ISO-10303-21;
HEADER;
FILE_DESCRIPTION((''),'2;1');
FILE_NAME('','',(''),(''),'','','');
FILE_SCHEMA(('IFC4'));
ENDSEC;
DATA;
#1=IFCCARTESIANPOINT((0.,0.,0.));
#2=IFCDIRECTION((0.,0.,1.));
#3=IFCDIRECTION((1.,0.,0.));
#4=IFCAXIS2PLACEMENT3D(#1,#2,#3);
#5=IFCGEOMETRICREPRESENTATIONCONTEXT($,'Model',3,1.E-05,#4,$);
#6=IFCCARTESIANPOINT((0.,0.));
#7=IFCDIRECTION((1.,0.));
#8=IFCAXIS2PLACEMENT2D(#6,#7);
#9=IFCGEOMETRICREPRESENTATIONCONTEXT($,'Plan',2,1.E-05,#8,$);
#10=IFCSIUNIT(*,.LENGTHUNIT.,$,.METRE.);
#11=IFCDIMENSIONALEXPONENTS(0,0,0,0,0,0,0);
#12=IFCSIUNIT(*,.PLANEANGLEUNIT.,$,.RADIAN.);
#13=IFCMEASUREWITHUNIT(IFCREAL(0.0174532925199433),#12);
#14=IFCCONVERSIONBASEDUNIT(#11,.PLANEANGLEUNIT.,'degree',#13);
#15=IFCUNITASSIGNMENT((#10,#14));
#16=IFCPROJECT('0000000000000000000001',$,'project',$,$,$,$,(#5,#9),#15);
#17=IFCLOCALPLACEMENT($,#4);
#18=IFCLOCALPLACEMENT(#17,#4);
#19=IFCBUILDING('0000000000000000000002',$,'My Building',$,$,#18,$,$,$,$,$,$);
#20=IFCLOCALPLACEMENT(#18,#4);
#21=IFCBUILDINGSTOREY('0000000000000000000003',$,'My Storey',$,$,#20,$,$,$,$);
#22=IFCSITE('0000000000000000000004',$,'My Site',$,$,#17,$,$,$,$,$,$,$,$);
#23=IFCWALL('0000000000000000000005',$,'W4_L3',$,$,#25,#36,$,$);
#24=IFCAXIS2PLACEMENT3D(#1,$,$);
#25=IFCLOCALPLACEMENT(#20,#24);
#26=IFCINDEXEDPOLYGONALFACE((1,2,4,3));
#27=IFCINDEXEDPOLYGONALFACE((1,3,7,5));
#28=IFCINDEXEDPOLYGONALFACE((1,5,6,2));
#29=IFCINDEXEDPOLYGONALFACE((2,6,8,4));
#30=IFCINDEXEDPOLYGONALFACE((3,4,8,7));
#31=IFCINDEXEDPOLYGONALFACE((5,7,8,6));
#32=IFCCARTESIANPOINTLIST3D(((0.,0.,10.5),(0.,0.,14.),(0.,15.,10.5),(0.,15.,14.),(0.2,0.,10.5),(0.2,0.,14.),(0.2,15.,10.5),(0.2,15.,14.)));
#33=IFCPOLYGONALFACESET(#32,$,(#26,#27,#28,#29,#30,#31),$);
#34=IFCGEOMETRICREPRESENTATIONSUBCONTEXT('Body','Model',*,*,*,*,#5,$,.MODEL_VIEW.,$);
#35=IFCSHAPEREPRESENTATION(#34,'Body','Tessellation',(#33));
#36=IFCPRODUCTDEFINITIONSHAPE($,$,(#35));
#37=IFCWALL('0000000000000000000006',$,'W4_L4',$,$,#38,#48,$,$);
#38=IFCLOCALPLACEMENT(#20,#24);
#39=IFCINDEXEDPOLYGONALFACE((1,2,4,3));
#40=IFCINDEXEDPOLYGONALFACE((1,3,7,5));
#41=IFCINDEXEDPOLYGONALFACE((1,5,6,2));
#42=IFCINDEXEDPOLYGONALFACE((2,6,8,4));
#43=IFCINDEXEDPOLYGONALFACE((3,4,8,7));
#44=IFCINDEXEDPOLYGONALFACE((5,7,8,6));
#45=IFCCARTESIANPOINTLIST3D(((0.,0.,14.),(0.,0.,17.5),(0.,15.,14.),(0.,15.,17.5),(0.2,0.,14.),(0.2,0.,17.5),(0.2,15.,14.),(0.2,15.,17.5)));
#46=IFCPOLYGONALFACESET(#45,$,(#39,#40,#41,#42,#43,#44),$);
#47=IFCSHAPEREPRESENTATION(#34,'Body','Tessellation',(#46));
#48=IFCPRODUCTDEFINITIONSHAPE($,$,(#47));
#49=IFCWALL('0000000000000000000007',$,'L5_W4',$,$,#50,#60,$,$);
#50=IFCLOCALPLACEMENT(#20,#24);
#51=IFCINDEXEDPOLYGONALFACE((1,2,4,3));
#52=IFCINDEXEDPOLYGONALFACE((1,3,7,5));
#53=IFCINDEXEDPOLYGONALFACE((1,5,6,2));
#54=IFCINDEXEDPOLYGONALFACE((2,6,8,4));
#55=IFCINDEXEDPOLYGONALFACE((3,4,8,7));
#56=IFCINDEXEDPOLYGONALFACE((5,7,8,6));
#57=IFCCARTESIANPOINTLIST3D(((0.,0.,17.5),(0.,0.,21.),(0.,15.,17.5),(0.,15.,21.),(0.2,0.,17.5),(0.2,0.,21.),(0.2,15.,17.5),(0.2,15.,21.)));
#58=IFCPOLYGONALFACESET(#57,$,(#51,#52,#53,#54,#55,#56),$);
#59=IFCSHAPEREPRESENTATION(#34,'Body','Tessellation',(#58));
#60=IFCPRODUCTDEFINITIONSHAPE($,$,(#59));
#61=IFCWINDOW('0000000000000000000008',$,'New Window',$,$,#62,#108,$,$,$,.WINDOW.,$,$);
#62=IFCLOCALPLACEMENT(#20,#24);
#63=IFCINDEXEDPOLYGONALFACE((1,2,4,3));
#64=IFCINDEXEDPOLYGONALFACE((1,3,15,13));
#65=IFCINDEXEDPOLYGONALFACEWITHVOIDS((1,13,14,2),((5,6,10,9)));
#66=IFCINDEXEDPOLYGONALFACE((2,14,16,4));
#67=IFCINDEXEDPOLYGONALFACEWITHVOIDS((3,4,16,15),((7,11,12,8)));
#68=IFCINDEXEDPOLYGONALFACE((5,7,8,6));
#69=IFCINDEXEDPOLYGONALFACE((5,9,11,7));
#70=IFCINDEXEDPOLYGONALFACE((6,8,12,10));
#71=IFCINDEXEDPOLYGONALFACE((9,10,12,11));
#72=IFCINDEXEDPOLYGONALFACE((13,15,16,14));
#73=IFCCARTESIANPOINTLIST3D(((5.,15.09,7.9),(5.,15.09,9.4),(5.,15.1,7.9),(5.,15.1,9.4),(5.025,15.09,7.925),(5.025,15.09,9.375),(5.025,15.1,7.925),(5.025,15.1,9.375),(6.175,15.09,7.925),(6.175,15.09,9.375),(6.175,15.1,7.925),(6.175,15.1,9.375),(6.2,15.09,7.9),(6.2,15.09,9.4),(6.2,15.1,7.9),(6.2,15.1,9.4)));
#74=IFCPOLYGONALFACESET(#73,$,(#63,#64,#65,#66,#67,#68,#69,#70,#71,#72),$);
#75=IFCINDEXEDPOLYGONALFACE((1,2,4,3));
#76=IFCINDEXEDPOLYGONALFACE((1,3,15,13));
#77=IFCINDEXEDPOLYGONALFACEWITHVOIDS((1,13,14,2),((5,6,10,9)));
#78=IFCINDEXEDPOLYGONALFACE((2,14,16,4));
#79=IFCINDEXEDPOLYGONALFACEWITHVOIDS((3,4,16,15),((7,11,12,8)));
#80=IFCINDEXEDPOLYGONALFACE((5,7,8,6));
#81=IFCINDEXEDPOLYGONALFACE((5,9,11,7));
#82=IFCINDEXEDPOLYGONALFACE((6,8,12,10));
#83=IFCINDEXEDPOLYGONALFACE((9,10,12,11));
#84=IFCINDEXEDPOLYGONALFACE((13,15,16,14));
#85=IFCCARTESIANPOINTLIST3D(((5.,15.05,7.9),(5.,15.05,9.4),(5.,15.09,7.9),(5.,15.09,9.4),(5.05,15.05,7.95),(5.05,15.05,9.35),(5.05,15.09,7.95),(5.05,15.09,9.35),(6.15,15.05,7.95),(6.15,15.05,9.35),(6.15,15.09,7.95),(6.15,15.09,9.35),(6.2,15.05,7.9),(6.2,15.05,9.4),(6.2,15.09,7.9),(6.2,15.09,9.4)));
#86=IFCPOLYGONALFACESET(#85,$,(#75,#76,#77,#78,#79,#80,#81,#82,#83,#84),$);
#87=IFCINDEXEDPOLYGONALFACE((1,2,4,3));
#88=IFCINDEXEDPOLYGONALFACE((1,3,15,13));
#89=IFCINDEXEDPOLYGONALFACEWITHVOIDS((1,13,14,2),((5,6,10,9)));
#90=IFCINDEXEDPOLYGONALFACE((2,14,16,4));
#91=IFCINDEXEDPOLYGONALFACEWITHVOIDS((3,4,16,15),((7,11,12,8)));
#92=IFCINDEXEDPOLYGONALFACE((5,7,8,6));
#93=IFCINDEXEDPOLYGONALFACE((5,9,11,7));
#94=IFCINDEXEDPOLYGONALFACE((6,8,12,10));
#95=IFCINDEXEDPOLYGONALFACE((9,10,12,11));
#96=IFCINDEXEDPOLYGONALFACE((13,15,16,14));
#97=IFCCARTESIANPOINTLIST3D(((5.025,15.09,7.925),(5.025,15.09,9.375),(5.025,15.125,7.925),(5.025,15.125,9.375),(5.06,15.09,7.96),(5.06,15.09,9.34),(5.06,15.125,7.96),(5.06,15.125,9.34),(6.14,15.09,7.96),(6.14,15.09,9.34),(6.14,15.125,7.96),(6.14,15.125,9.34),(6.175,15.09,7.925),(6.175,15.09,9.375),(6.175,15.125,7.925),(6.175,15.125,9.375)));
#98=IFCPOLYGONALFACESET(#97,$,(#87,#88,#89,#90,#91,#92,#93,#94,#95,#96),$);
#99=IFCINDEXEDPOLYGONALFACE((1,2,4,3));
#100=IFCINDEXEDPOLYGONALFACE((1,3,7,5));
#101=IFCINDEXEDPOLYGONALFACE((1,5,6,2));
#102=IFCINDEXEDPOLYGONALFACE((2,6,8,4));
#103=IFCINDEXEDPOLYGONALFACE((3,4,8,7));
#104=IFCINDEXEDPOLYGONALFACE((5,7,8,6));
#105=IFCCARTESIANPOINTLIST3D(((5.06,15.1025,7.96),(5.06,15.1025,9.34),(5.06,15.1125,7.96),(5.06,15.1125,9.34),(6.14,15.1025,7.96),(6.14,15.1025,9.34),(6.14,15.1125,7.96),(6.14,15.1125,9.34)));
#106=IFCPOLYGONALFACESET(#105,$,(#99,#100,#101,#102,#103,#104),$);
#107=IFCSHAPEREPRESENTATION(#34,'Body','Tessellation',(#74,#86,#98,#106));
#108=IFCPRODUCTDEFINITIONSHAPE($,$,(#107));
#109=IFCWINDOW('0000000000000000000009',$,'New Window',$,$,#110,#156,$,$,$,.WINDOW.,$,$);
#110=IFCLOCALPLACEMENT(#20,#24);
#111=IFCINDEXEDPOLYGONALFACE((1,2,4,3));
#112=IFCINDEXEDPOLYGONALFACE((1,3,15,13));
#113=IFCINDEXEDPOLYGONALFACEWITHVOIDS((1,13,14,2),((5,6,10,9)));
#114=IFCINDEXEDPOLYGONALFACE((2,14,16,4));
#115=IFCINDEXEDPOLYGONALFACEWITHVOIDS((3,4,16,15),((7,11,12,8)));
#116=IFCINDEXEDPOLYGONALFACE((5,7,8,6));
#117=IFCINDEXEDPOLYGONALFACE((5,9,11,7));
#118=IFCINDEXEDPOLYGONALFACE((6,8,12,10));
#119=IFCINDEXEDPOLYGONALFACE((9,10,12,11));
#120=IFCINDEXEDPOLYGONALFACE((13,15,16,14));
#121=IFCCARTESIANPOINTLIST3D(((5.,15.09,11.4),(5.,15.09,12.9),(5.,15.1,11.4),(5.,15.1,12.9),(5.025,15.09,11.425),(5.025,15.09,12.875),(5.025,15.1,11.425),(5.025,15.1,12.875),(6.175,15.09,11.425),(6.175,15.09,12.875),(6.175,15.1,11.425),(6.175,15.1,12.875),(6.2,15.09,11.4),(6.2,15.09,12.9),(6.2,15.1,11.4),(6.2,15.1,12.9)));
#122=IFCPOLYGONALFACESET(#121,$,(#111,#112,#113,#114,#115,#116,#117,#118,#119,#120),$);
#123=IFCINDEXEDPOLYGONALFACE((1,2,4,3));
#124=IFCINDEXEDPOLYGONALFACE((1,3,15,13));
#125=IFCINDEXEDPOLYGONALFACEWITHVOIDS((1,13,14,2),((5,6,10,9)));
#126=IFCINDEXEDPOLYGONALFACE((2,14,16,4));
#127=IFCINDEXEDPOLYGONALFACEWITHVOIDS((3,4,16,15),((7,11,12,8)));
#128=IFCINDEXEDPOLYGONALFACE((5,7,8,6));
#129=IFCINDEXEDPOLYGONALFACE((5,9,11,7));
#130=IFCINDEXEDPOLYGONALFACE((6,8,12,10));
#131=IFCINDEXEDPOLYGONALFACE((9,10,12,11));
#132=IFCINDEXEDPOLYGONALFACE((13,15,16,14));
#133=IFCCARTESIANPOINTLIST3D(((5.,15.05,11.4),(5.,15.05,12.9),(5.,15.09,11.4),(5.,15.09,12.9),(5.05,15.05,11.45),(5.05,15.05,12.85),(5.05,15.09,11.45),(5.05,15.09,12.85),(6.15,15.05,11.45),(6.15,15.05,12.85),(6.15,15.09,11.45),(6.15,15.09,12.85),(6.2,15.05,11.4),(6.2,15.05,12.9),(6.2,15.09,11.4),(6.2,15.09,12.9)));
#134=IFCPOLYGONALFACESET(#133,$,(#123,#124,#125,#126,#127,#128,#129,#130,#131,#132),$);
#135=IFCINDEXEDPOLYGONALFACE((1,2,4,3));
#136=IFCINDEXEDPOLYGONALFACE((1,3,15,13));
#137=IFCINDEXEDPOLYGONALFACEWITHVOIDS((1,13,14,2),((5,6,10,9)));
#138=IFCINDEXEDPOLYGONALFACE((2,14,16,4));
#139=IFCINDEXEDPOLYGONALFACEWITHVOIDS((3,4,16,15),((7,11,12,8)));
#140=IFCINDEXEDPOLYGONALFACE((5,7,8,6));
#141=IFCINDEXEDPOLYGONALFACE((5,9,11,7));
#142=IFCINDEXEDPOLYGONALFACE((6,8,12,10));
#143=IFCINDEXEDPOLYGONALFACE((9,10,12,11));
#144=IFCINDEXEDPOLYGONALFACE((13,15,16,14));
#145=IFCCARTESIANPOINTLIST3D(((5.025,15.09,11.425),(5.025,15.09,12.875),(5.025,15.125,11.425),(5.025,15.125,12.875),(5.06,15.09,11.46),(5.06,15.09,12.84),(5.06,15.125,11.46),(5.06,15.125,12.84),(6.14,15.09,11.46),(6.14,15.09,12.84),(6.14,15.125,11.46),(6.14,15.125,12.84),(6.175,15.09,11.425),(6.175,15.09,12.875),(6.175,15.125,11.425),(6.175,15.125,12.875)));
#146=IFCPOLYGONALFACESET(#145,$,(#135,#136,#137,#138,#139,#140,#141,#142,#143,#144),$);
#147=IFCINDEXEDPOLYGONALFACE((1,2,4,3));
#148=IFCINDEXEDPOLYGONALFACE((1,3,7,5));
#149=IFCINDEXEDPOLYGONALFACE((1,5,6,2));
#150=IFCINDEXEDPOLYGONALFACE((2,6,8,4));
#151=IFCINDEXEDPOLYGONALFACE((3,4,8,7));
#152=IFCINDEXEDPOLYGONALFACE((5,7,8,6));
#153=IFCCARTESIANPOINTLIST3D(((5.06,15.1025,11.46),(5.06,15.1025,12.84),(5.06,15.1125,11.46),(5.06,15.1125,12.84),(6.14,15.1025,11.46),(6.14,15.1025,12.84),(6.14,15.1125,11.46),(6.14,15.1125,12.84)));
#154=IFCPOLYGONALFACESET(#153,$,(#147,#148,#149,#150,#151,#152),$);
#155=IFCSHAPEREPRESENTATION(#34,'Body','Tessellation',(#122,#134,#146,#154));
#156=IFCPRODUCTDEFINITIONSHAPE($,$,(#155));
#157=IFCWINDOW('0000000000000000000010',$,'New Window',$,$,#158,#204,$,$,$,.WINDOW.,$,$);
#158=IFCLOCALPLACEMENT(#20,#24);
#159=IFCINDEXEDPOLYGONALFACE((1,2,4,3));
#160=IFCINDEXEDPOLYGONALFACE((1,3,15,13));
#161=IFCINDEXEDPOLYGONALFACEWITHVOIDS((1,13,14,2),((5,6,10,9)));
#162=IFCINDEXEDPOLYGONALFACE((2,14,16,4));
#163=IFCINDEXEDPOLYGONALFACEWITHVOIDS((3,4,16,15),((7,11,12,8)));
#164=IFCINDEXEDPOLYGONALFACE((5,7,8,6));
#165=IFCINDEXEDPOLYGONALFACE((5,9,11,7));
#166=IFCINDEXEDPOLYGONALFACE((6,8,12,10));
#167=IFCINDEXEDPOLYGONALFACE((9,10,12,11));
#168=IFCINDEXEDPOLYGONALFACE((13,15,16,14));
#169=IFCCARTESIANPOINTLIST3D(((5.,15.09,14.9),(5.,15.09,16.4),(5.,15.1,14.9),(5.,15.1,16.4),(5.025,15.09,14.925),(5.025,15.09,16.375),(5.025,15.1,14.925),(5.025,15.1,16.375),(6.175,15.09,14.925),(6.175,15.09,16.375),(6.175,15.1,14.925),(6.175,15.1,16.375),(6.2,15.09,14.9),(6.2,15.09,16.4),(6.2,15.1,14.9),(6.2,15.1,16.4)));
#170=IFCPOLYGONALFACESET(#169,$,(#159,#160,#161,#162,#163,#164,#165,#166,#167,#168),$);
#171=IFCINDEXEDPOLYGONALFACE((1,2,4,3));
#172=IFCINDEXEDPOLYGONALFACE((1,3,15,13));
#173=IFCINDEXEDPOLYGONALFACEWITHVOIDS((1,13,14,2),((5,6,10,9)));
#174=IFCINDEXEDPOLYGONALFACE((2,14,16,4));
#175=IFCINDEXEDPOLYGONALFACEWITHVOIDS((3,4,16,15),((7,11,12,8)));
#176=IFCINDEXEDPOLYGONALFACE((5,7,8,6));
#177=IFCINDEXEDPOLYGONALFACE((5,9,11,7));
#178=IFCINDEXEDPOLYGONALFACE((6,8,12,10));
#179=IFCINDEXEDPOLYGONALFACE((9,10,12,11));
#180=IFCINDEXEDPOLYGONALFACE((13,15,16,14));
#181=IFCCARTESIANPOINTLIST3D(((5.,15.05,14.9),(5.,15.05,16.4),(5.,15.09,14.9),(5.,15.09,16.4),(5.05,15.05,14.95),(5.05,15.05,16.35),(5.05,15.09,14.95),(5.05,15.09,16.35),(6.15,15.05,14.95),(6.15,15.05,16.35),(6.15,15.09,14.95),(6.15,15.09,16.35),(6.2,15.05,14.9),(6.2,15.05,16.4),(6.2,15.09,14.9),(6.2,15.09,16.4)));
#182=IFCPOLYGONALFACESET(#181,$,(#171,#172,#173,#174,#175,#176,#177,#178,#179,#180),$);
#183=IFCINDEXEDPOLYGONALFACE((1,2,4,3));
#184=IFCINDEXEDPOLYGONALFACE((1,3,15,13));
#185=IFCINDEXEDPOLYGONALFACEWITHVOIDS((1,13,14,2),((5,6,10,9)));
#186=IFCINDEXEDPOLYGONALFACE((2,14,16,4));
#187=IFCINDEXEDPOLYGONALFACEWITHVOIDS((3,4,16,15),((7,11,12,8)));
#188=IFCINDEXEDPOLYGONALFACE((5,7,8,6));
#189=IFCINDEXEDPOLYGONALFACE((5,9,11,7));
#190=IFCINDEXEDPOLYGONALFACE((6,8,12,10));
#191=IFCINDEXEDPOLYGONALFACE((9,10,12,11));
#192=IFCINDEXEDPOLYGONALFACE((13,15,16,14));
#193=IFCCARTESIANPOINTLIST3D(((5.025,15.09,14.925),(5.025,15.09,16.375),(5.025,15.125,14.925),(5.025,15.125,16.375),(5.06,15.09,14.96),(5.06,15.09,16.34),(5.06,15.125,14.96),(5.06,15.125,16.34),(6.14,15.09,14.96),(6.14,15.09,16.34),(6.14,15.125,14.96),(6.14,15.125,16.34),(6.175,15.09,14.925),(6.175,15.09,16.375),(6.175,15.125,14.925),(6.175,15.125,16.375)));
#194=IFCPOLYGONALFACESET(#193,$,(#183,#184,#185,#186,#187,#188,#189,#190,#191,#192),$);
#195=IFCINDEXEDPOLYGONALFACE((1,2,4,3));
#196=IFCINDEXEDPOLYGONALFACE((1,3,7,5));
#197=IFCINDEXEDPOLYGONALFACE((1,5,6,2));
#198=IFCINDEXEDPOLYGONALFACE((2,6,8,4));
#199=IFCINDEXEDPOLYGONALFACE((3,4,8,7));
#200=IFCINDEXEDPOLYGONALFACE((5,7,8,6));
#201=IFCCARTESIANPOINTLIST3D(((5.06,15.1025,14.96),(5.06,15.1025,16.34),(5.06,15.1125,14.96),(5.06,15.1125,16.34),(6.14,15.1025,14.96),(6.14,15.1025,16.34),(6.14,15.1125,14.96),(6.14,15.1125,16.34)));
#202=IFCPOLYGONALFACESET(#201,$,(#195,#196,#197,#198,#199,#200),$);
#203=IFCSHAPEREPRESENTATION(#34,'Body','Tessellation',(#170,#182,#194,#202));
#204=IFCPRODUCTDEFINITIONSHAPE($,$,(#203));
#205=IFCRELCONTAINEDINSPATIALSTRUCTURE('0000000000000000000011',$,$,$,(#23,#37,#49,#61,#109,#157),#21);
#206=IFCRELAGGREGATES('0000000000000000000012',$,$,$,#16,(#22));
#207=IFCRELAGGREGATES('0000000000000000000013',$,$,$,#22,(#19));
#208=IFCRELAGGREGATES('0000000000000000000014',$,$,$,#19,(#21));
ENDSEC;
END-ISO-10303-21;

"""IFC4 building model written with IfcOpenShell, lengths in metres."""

from ifc_helpers import new_model, entity, si_unit, converted_unit, frame, origin_with_axes, origin_2d_with_axis, place, context, subcontext, project, spatial, line, indexed_curve, outline, extrude, element, save


model = new_model("IFC4")

# Units and contexts
model_context = context("Model", 3, precision=1e-05, world=origin_with_axes())
plan_context = context("Plan", 2, precision=1e-05, world=origin_2d_with_axis())
body_context = subcontext(model_context, "Body", "Model", "MODEL_VIEW")
ifc_project = project(units=[si_unit("LENGTHUNIT", "METRE"), converted_unit("PLANEANGLEUNIT", "degree", entity("IfcReal", 0.0174532925199433), si_unit("PLANEANGLEUNIT", "RADIAN"), dimensions=[0, 0, 0, 0, 0, 0, 0])], contexts=[model_context, plan_context])

# Site, building, storey
site_placement = place(None, origin_with_axes())
site = spatial("IfcSite", under=ifc_project, at=site_placement, Name="My Site")
building_placement = place(site_placement, origin_with_axes())
building = spatial("IfcBuilding", under=site, at=building_placement, Name="My Building")
storey_placement = place(building_placement, origin_with_axes())
storey = spatial("IfcBuildingStorey", under=building, at=storey_placement, Name="My Storey")

# Walls
for number, where, z_axis, x_axis, name in (
    (1, (0.0, 15.0, 10.5), (0.0, 0.0, 1.0), (0.0, -1.0, 0.0), "W4_L3"),
    (2, (0.0, 15.0, 14.0), (0.0, 0.0, 1.0), (0.0, -1.0, 0.0), "W4_L4"),
    (3, (0.0, 15.0, 17.5), (0.0, 0.0, 1.0), (0.0, -1.0, 0.0), "L5_W4"),
):
    element("IfcWall", number, at=place(storey_placement, frame(where, z_axis=z_axis, x_axis=x_axis)), inside=storey, Name=name, context=body_context, shape_type="SweptSolid", body=[
        extrude(outline(indexed_curve([(0.0, 0.0), (0.0, 0.2), (15.0, 0.2), (15.0, 0.0), (0.0, 0.0)], self_intersect=False)), origin_with_axes(), (0.0, 0.0, 1.0), 3.5),
    ])

# Windows
for number, where, z_axis, x_axis, name in (
    (4, (5.0, 15.0, 7.9), (0.0, 0.0, 1.0), (1.0, 0.0, 0.0), "New Window"),
    (5, (5.0, 15.0, 11.4), (0.0, 0.0, 1.0), (1.0, 0.0, 0.0), "New Window"),
    (6, (5.0, 15.0, 14.9), (0.0, 0.0, 1.0), (1.0, 0.0, 0.0), "New Window"),
):
    element("IfcWindow", number, at=place(storey_placement, frame(where, z_axis=z_axis, x_axis=x_axis)), inside=storey, Name=name, PredefinedType="WINDOW", context=body_context, shape_type="SweptSolid", body=[
        extrude(outline(indexed_curve([(0.0, 0.0), (1.2, 0.0), (1.2, 1.5), (0.0, 1.5)], segments=[line(1, 2, 3, 4, 1)]), holes=[indexed_curve([(0.025, 0.025), (1.175, 0.025), (1.175, 1.475), (0.025, 1.475)], segments=[line(1, 2, 3, 4, 1)])]), frame((0.0, 0.09, 0.0), z_axis=(0.0, -1.0, 0.0), x_axis=(1.0, 0.0, 0.0)), (0.0, 0.0, -1.0), 0.01),
        extrude(outline(indexed_curve([(0.0, 0.0), (1.2, 0.0), (1.2, 1.5), (0.0, 1.5)], segments=[line(1, 2, 3, 4, 1)]), holes=[indexed_curve([(0.05, 0.05), (1.15, 0.05), (1.15, 1.45), (0.05, 1.45)], segments=[line(1, 2, 3, 4, 1)])]), frame((0.0, 0.05, 0.0), z_axis=(0.0, -1.0, 0.0), x_axis=(1.0, 0.0, 0.0)), (0.0, 0.0, -1.0), 0.04),
        extrude(outline(indexed_curve([(0.0, 0.0), (1.15, 0.0), (1.15, 1.45), (0.0, 1.45)], segments=[line(1, 2, 3, 4, 1)]), holes=[indexed_curve([(0.035, 0.035), (1.115, 0.035), (1.115, 1.415), (0.035, 1.415)], segments=[line(1, 2, 3, 4, 1)])]), frame((0.025, 0.09, 0.025), z_axis=(0.0, -1.0, 0.0), x_axis=(1.0, 0.0, 0.0)), (0.0, 0.0, -1.0), 0.035),
        extrude(outline(indexed_curve([(0.035, 0.035), (1.115, 0.035), (1.115, 1.415), (0.035, 1.415)], segments=[line(1, 2, 3, 4, 1)])), frame((0.025, 0.1025, 0.025), z_axis=(0.0, -1.0, 0.0), x_axis=(1.0, 0.0, 0.0)), (0.0, 0.0, -1.0), 0.01),
    ])

save(model, "model.ifc")
